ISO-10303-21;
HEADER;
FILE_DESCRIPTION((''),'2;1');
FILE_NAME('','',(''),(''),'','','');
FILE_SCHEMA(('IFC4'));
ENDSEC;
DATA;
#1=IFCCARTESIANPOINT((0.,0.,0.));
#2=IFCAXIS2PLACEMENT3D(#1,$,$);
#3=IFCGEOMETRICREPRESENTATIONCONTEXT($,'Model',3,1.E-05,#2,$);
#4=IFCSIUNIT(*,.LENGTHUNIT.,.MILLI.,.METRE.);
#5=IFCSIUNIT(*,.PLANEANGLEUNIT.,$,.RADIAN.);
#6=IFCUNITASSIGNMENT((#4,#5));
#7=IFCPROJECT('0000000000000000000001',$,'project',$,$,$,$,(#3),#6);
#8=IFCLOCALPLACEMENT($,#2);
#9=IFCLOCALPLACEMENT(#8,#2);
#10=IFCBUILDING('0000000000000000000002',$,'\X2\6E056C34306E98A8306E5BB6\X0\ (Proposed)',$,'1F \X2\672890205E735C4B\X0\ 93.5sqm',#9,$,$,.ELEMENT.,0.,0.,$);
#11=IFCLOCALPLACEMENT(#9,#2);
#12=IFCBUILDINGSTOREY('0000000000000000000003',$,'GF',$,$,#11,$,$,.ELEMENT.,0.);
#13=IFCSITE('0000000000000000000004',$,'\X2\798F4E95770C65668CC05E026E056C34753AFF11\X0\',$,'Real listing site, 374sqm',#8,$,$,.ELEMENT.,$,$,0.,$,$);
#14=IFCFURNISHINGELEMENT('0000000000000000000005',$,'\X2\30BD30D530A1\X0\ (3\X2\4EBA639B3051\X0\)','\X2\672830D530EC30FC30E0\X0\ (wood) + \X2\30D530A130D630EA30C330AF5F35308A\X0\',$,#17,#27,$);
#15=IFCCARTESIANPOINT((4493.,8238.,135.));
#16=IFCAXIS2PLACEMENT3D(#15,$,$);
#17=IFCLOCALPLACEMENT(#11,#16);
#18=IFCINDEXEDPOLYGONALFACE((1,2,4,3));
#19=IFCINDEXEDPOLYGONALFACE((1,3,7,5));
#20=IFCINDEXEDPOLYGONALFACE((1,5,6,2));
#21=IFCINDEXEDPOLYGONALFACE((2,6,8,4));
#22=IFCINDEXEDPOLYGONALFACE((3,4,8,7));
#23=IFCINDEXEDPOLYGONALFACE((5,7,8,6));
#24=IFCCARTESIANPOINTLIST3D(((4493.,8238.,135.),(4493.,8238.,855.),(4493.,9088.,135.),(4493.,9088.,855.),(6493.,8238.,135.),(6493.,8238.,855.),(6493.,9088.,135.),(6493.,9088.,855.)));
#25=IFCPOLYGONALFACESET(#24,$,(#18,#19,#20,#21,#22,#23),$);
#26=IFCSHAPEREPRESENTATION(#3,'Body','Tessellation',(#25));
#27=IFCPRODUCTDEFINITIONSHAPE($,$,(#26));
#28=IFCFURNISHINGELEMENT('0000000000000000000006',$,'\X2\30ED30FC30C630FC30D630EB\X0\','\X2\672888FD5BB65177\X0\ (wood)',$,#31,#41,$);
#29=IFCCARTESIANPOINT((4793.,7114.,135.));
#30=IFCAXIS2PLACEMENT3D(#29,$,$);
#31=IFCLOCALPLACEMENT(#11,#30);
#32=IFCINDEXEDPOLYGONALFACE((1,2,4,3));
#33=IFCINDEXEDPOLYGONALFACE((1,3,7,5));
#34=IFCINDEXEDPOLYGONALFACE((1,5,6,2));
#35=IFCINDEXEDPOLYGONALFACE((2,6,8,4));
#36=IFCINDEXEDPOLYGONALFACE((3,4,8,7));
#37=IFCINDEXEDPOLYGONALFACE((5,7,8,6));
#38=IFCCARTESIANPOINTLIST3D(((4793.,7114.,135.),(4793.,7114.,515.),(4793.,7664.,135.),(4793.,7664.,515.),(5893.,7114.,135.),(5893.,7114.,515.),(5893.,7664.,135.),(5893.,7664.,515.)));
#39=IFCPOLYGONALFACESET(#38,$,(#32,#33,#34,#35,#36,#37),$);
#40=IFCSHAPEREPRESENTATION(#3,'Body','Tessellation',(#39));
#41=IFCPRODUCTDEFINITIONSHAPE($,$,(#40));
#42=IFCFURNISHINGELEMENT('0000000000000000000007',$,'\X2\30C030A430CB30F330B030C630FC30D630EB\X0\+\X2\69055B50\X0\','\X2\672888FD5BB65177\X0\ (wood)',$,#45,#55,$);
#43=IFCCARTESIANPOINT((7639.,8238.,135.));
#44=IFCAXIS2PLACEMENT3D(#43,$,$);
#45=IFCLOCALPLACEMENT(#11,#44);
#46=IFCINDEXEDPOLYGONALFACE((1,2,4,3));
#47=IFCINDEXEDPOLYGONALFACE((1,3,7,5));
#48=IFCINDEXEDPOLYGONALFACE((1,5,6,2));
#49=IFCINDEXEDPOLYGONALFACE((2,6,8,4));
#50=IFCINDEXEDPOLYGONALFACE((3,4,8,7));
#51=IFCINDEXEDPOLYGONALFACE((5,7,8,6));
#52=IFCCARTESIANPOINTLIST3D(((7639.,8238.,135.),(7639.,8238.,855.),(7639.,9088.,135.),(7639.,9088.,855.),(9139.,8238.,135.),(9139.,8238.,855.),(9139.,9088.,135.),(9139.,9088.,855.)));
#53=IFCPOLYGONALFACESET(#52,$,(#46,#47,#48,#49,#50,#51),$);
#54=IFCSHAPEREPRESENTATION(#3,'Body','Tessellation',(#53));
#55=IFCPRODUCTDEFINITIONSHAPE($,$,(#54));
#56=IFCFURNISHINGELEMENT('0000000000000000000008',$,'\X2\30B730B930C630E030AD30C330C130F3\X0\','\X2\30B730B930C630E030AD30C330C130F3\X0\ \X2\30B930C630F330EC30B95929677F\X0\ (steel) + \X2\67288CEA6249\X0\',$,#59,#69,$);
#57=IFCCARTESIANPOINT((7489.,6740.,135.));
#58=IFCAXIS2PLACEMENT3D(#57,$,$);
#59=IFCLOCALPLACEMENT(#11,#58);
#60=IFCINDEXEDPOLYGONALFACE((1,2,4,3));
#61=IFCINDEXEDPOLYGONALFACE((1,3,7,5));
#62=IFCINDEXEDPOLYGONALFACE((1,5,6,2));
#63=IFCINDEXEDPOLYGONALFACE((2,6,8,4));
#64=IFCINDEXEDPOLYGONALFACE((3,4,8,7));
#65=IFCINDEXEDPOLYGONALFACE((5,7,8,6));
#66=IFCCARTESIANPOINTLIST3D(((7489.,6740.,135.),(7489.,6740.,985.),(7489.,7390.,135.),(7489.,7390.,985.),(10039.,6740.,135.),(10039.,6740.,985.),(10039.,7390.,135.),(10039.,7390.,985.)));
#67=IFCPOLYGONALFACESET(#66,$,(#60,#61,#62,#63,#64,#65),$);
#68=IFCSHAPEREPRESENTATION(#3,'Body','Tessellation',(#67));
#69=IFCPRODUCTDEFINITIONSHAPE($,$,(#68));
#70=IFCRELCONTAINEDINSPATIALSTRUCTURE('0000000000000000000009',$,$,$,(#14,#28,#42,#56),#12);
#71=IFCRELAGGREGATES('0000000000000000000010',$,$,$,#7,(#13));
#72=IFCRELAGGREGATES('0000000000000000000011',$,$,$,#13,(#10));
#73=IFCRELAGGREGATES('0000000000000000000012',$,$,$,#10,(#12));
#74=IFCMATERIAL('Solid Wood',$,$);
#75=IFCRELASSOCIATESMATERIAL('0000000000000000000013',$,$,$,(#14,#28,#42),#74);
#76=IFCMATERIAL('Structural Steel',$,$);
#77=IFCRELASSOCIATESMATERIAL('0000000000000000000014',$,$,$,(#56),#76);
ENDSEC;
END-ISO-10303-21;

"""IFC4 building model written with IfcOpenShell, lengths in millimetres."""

from ifc_helpers import new_model, si_unit, frame, frame_2d, origin, place, context, project, spatial, rectangle, extrude, material, element, save


model = new_model("IFC4")

# Units and contexts
model_context = context("Model", 3, precision=1e-05, world=origin())
ifc_project = project(units=[si_unit("LENGTHUNIT", "METRE", prefix="MILLI"), si_unit("PLANEANGLEUNIT", "RADIAN")], contexts=[model_context])

# Site, building, storey
site_placement = place(None, origin())
site = spatial("IfcSite", under=ifc_project, at=site_placement, Name="福井県敦賀市清水町１", ObjectType="Real listing site, 374sqm", CompositionType="ELEMENT", RefElevation=0.0)
building_placement = place(site_placement, origin())
building = spatial("IfcBuilding", under=site, at=building_placement, Name="清水の風の家 (Proposed)", ObjectType="1F 木造平屋 93.5sqm", CompositionType="ELEMENT", ElevationOfRefHeight=0.0, ElevationOfTerrain=0.0)
storey_placement = place(building_placement, origin())
storey = spatial("IfcBuildingStorey", under=building, at=storey_placement, Name="GF", CompositionType="ELEMENT", Elevation=0.0)

# Shared definitions
ifc_material_1 = material(Name="Solid Wood")

# Shared definitions
ifc_material_2 = material(Name="Structural Steel")

# Furnishing elements
furnishing_1_placement = place(storey_placement, frame((4493.0, 8238.0, 135.0)))
element("IfcFurnishingElement", 1, at=furnishing_1_placement, inside=storey, material=ifc_material_1, Name="ソファ (3人掛け)", Description="木フレーム (wood) + ファブリック張り", context=model_context, shape_type="SweptSolid", body=[
    extrude(rectangle(XDim=2000.0, YDim=850.0, at=frame_2d((1000.0, 425.0))), frame((4493.0, 8238.0, 135.0)), (0.0, 0.0, 1.0), 720.0),
])
furnishing_2_placement = place(storey_placement, frame((4793.0, 7114.0, 135.0)))
element("IfcFurnishingElement", 2, at=furnishing_2_placement, inside=storey, material=ifc_material_1, Name="ローテーブル", Description="木製家具 (wood)", context=model_context, shape_type="SweptSolid", body=[
    extrude(rectangle(XDim=1100.0, YDim=550.0, at=frame_2d((550.0, 275.0))), frame((4793.0, 7114.0, 135.0)), (0.0, 0.0, 1.0), 380.0),
])
furnishing_3_placement = place(storey_placement, frame((7639.0, 8238.0, 135.0)))
element("IfcFurnishingElement", 3, at=furnishing_3_placement, inside=storey, material=ifc_material_1, Name="ダイニングテーブル+椅子", Description="木製家具 (wood)", context=model_context, shape_type="SweptSolid", body=[
    extrude(rectangle(XDim=1500.0, YDim=850.0, at=frame_2d((750.0, 425.0))), frame((7639.0, 8238.0, 135.0)), (0.0, 0.0, 1.0), 720.0),
])
furnishing_4_placement = place(storey_placement, frame((7489.0, 6740.0, 135.0)))
element("IfcFurnishingElement", 4, at=furnishing_4_placement, inside=storey, material=ifc_material_2, Name="システムキッチン", Description="システムキッチン ステンレス天板 (steel) + 木質扉", context=model_context, shape_type="SweptSolid", body=[
    extrude(rectangle(XDim=2550.0, YDim=650.0, at=frame_2d((1275.0, 325.0))), frame((7489.0, 6740.0, 135.0)), (0.0, 0.0, 1.0), 850.0),
])

save(model, "model.ifc")
